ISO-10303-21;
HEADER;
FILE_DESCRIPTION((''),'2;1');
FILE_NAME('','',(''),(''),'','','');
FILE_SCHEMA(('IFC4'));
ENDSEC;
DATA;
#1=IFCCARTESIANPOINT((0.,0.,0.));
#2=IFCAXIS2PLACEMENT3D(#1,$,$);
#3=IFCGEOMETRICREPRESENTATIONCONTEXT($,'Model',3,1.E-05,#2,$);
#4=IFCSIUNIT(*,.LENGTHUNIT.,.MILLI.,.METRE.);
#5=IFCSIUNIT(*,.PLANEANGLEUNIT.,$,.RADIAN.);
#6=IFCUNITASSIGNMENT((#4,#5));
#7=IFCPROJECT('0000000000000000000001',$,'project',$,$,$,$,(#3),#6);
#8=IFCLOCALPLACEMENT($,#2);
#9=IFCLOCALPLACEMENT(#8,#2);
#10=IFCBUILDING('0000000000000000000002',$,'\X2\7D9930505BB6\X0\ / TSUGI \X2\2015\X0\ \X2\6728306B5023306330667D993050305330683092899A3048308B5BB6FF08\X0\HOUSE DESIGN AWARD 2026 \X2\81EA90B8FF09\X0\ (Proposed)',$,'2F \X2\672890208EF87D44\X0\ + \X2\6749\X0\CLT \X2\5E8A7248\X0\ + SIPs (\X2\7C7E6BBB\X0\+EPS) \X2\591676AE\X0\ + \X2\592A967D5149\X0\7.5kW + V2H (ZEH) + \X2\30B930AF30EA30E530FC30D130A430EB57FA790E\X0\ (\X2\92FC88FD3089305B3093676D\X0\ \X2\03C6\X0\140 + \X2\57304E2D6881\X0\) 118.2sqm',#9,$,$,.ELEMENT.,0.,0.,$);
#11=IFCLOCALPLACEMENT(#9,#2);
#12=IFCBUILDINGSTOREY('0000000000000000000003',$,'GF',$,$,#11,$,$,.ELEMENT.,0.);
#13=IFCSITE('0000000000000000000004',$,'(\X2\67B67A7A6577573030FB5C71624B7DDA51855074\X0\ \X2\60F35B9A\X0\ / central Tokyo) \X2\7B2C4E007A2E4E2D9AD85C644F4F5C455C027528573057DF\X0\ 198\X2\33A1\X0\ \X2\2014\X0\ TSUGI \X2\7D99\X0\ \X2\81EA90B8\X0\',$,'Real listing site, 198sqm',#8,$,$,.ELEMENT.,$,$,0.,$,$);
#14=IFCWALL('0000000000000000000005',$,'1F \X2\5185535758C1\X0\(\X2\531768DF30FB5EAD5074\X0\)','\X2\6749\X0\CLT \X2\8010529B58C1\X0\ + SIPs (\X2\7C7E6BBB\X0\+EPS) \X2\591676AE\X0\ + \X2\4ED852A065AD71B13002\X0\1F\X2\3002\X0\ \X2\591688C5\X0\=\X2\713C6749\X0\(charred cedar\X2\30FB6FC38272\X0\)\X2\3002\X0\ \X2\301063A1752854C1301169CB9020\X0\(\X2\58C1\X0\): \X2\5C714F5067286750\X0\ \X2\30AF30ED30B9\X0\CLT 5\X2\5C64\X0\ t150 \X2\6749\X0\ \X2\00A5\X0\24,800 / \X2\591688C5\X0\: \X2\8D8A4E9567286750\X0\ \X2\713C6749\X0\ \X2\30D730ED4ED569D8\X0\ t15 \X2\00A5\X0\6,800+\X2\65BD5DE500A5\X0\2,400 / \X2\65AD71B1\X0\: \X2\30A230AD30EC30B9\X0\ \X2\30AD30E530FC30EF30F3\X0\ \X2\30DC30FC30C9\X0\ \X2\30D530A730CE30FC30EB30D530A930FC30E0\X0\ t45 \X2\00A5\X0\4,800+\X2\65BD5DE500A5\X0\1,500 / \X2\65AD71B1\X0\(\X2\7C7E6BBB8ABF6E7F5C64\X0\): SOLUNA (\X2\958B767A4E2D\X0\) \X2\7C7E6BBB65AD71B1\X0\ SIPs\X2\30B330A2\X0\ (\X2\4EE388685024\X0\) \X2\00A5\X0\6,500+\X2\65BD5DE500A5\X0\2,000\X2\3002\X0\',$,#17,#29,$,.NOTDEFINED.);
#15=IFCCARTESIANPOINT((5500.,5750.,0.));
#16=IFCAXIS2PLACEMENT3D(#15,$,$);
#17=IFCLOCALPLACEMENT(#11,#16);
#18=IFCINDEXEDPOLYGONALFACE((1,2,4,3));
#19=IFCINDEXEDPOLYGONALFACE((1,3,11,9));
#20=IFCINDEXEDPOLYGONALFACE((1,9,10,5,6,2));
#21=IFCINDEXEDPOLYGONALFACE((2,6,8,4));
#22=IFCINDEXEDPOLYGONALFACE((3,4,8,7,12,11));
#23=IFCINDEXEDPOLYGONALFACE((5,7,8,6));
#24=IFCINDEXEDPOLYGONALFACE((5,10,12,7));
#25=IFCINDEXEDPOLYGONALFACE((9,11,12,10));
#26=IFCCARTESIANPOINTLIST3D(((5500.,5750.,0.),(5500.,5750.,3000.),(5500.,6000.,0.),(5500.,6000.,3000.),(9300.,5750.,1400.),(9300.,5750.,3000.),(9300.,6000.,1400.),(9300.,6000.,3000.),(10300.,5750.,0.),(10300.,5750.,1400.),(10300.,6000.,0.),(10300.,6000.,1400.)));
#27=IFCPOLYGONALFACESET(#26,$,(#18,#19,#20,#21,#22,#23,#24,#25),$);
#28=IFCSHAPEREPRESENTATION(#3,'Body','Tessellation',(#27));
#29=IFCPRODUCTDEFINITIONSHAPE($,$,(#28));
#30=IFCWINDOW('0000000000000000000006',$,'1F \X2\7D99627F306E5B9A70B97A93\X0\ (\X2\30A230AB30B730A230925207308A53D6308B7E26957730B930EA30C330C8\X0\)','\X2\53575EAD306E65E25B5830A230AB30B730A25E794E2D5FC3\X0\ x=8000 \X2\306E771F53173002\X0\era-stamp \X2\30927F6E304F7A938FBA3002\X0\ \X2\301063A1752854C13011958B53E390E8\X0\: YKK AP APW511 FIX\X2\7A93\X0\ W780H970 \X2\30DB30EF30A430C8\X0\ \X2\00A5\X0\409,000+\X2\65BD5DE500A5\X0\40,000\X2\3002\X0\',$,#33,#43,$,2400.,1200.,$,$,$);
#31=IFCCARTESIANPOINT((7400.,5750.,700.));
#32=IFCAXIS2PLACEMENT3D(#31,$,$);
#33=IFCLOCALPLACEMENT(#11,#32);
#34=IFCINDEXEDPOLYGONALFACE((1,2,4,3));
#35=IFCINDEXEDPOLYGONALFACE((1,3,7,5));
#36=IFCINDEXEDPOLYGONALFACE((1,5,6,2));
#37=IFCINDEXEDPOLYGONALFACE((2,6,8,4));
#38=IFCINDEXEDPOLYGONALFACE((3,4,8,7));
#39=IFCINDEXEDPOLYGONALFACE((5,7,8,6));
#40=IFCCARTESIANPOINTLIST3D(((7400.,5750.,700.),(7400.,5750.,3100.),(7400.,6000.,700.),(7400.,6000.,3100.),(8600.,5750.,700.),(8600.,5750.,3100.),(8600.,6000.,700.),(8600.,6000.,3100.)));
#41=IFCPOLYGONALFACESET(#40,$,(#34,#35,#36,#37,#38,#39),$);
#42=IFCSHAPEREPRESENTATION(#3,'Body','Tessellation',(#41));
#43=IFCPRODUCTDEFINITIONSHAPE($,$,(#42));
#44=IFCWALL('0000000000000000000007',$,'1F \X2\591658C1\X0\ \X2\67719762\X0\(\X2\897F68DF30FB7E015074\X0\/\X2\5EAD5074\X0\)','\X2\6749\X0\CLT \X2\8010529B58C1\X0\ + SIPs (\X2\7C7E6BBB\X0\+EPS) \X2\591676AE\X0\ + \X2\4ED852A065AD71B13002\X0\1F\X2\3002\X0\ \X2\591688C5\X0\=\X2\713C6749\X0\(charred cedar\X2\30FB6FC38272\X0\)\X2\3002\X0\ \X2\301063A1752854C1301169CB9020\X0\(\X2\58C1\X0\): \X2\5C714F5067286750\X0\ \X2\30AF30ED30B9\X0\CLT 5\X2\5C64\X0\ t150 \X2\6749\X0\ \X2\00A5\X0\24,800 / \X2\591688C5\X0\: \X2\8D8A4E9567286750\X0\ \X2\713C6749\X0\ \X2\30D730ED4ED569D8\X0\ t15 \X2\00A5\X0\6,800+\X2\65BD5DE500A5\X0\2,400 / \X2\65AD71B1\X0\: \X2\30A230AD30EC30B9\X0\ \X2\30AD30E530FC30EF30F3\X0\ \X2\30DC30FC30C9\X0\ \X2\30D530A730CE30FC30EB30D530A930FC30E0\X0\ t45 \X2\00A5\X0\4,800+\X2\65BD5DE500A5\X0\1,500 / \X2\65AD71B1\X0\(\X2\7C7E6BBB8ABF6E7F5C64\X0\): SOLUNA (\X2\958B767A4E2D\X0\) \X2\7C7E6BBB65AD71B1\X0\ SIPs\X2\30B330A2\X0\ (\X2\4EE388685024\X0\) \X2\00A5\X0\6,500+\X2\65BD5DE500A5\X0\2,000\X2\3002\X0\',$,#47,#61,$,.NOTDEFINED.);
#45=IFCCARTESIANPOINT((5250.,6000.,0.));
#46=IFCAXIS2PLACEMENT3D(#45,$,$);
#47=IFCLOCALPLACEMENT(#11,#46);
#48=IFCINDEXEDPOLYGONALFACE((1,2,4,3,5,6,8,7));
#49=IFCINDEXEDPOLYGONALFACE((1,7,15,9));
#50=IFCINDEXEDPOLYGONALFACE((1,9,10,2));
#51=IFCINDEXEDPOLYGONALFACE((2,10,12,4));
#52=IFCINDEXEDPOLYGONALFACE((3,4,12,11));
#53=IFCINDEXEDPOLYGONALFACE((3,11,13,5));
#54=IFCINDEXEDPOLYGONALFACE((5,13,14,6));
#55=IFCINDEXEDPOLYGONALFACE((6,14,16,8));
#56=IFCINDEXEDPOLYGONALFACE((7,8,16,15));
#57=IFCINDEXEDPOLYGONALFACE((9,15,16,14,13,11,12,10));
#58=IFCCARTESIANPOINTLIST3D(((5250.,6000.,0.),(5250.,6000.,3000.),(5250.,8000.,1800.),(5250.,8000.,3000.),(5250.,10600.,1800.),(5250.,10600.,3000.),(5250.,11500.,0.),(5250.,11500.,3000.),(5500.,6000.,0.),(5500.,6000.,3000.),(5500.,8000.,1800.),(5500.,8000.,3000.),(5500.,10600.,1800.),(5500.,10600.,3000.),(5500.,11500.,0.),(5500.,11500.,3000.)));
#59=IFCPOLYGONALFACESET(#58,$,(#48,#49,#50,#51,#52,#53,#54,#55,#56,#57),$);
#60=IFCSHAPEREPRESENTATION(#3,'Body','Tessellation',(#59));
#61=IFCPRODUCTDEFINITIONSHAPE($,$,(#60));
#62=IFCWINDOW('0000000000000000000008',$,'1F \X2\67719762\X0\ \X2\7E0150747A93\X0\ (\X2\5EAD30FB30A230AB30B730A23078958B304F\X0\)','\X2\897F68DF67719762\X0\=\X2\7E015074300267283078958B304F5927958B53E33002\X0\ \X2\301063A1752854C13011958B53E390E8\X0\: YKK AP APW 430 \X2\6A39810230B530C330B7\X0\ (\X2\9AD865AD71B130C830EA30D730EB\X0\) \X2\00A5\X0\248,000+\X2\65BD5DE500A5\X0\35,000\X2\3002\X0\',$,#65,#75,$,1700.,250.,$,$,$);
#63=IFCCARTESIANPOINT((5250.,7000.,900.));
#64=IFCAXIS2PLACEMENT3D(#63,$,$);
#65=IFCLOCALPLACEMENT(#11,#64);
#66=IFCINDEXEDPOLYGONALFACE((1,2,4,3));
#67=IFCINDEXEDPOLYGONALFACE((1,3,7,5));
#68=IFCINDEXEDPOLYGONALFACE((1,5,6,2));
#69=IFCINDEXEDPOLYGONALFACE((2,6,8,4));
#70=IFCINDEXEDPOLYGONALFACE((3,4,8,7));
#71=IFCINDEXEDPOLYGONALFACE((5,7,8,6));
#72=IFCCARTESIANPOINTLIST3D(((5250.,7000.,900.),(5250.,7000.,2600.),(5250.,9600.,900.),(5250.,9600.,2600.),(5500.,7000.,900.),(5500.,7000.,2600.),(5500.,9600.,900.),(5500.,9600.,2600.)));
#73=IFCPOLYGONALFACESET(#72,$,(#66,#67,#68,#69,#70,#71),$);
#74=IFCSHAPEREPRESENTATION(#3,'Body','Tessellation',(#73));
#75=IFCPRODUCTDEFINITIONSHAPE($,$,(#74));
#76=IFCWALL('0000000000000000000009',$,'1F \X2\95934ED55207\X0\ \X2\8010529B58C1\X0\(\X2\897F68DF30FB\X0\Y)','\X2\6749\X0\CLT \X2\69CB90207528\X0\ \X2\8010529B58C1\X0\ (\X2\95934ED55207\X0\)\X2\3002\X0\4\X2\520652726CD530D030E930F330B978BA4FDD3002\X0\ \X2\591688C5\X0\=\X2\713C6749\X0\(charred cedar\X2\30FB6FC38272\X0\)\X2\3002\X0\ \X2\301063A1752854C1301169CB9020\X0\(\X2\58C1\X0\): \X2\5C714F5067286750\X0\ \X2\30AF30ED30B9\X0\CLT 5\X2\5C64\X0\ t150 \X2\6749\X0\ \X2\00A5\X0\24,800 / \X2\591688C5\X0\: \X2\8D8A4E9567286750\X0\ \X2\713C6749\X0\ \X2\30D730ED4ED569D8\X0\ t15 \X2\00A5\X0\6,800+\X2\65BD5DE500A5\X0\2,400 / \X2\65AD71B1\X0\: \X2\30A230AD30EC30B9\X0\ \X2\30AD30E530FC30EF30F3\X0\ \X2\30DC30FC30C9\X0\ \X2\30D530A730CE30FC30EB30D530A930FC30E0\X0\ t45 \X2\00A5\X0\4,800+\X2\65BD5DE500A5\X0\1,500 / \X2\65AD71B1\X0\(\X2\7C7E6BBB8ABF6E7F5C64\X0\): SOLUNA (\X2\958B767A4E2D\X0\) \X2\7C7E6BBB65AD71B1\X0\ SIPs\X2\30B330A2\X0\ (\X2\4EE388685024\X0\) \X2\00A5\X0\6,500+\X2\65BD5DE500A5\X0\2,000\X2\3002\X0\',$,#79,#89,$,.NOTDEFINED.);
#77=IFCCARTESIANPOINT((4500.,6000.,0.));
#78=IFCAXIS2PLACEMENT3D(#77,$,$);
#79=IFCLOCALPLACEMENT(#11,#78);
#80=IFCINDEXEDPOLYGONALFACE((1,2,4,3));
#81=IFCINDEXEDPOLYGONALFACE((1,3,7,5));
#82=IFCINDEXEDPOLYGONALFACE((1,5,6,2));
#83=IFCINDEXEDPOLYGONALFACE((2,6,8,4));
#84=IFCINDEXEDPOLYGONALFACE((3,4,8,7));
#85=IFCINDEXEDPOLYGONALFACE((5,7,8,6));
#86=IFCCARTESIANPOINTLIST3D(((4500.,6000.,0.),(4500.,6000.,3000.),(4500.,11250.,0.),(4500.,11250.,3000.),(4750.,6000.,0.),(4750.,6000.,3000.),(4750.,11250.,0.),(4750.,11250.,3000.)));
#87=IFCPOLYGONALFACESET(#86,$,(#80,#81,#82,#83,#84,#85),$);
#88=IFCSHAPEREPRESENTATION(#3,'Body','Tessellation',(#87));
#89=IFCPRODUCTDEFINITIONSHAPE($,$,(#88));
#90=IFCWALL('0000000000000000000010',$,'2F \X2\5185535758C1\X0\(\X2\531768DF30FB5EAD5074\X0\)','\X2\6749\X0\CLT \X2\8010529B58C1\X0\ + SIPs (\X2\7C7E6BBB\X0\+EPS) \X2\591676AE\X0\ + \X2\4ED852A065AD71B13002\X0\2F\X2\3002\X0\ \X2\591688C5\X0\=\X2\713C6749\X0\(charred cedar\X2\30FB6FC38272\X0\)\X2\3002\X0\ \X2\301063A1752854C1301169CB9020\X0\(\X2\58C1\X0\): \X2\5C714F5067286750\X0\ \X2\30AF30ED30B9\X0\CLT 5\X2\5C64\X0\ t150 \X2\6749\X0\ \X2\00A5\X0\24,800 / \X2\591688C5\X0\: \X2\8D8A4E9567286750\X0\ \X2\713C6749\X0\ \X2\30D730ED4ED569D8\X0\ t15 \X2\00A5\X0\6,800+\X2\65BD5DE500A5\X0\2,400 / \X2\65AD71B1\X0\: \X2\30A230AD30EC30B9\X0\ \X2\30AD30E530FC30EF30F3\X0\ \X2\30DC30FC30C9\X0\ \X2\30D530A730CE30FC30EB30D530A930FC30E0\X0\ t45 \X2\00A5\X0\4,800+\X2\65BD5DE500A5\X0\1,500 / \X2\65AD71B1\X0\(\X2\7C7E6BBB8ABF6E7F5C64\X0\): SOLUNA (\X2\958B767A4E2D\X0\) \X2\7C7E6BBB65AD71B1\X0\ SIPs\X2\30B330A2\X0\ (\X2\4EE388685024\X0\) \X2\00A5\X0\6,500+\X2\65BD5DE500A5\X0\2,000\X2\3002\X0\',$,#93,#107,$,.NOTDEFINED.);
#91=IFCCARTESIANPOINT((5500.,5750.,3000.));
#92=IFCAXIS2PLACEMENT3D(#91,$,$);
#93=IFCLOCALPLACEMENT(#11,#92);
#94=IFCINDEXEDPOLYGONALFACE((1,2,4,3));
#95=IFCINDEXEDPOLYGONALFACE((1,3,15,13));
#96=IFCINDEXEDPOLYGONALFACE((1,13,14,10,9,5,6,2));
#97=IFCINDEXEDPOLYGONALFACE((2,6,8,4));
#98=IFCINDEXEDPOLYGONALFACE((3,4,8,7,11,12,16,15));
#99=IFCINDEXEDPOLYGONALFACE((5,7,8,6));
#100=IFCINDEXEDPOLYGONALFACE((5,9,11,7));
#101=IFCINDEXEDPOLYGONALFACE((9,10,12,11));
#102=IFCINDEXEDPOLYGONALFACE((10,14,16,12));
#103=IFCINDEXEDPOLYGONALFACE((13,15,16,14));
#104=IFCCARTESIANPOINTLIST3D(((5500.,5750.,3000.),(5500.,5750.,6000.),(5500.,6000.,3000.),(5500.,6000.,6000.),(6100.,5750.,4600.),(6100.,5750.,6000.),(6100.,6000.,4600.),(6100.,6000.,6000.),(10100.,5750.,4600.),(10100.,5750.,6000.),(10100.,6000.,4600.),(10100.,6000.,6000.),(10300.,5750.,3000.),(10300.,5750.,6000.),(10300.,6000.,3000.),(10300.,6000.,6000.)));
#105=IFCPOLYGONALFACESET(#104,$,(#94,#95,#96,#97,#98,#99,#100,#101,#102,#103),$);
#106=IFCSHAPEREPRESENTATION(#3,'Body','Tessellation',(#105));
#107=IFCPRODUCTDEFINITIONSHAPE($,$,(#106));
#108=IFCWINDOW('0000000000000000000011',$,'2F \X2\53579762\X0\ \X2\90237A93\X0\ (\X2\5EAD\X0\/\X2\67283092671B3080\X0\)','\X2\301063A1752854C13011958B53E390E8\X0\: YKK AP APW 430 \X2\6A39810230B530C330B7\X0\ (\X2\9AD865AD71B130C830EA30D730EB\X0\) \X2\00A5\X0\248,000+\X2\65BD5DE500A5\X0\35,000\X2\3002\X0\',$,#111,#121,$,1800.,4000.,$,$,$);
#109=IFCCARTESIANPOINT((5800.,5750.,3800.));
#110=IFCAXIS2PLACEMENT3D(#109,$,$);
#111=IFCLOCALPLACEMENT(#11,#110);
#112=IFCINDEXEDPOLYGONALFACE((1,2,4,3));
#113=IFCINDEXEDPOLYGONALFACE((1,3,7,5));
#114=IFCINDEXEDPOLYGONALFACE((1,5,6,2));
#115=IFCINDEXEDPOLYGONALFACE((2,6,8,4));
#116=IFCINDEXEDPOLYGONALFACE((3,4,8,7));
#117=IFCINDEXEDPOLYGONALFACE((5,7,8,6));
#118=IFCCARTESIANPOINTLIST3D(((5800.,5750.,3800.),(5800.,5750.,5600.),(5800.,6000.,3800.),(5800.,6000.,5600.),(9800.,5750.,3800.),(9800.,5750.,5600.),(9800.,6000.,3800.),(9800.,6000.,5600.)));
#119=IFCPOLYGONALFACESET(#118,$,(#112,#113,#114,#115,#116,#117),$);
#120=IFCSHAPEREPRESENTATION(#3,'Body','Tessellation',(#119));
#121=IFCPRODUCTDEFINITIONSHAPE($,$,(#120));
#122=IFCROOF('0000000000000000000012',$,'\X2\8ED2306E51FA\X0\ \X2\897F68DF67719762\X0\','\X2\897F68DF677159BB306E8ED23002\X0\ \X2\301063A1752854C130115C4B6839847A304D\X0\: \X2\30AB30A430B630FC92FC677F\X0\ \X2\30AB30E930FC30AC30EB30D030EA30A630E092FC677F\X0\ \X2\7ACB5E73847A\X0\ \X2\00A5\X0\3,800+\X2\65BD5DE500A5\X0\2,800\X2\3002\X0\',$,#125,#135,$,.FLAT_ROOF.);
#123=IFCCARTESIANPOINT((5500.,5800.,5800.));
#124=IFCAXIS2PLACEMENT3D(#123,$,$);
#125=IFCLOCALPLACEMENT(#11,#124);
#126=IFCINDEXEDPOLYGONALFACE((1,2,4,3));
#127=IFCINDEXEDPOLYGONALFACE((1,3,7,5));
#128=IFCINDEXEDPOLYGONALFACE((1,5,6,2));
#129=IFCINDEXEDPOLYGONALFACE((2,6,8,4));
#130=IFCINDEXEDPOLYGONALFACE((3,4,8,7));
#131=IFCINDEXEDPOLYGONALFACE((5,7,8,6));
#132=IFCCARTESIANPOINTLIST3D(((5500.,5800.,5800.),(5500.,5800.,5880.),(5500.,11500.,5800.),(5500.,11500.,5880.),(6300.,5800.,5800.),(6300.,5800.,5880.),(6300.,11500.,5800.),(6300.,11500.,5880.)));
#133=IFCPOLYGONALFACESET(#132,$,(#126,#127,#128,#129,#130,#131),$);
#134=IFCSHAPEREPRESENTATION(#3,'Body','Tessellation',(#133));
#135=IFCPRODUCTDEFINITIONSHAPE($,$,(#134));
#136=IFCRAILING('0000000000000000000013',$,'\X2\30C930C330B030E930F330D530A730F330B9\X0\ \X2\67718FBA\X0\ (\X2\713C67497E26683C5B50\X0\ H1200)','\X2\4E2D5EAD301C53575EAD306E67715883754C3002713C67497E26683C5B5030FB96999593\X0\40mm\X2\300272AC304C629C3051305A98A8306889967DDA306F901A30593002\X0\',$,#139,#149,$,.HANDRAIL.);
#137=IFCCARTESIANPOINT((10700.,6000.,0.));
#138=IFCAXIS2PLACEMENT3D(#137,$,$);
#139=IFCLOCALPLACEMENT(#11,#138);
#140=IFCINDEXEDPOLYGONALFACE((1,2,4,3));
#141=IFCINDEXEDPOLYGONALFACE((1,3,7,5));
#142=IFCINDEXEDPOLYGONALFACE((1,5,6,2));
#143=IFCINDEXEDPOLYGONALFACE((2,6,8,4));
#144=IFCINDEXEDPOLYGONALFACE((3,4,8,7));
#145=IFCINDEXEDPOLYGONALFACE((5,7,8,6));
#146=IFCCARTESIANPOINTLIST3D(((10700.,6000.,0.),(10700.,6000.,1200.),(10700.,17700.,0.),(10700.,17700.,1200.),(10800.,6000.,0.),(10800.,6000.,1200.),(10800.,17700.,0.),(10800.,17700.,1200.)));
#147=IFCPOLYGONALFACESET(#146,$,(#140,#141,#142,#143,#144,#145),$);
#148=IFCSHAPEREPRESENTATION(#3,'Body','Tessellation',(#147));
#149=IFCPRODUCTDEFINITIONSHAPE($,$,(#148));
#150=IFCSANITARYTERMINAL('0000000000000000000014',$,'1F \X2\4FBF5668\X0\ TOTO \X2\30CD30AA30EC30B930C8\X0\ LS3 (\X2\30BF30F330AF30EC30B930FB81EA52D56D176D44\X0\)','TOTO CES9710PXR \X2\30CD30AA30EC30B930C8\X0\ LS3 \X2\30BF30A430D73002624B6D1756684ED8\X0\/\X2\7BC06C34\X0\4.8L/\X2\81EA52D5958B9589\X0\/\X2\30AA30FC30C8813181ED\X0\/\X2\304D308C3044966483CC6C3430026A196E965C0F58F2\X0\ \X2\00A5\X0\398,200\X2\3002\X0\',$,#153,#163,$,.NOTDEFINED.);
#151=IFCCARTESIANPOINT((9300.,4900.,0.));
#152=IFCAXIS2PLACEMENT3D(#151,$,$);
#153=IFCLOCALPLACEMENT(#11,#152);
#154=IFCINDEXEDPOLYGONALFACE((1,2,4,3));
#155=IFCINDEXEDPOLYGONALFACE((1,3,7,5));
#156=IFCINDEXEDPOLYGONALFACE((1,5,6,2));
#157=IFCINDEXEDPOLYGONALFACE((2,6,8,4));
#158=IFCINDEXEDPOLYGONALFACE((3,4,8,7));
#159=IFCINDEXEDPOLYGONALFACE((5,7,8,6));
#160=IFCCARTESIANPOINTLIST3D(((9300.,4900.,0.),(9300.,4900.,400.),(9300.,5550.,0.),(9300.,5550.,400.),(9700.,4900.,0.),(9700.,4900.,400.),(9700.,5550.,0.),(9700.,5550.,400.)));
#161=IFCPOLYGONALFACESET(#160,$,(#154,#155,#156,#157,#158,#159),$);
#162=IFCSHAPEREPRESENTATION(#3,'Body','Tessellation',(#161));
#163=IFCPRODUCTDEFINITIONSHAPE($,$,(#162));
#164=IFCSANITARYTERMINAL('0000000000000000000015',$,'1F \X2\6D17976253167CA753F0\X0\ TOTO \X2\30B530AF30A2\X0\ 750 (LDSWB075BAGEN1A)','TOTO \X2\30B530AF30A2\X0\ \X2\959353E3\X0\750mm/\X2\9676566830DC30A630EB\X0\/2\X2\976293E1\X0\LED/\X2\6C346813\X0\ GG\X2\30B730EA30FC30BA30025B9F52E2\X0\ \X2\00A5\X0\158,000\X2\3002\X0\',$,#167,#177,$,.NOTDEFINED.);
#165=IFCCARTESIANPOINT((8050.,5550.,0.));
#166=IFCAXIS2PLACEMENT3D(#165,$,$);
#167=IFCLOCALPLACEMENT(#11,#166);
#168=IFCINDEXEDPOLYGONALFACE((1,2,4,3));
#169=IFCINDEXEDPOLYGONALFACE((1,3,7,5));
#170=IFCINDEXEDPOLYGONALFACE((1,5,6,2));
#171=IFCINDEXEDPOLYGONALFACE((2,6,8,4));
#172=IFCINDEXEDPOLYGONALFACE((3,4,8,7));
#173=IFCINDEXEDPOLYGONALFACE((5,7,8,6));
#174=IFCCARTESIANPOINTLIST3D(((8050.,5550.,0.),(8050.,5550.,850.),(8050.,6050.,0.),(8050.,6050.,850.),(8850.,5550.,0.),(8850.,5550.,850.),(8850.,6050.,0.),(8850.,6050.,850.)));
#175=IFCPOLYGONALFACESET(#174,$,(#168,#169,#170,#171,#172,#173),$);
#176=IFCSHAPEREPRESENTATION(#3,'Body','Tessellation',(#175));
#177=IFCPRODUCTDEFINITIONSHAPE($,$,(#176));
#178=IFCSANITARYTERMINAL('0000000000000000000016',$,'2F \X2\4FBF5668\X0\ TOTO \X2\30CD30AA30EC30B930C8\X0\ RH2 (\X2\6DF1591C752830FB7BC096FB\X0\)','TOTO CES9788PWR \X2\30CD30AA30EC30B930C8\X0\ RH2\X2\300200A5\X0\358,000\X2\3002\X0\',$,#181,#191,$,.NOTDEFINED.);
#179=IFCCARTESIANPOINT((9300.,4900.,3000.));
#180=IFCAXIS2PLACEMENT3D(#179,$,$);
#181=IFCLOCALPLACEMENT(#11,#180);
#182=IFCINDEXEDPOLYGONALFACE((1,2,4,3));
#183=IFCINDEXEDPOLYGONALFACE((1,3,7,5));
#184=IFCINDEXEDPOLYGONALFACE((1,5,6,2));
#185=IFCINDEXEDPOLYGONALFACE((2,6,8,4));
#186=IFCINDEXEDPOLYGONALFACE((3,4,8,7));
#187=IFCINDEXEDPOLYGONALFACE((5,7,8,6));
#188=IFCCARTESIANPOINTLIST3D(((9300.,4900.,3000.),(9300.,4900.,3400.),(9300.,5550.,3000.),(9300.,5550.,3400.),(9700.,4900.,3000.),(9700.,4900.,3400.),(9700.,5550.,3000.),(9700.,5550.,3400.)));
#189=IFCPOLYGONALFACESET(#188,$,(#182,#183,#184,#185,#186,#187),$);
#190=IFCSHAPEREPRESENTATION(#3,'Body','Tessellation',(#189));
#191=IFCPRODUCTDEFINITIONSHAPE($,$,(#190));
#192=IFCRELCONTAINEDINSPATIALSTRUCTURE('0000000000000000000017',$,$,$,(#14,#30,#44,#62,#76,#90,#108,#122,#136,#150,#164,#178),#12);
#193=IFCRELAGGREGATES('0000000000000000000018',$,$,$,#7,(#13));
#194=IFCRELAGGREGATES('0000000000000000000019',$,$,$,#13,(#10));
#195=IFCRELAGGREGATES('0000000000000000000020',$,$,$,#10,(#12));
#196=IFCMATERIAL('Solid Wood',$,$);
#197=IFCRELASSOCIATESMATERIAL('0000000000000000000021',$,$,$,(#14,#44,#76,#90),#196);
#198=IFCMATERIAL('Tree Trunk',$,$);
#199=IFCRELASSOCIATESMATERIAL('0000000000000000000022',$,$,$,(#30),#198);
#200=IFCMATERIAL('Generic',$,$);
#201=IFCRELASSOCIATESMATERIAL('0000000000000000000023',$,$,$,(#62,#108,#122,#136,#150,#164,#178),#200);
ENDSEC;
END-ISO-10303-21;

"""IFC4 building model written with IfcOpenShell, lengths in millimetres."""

from ifc_helpers import new_model, si_unit, frame, frame_2d, origin, place, context, project, spatial, rectangle, extrude, material, element, fill, save


model = new_model("IFC4")

# Units and contexts
model_context = context("Model", 3, precision=1e-05, world=origin())
ifc_project = project(units=[si_unit("LENGTHUNIT", "METRE", prefix="MILLI"), si_unit("PLANEANGLEUNIT", "RADIAN")], contexts=[model_context])

# Site, building, storey
site_placement = place(None, origin())
site = spatial("IfcSite", under=ifc_project, at=site_placement, Name="(架空敷地・山手線内側 想定 / central Tokyo) 第一種中高層住居専用地域 198㎡ — TSUGI 継 自邸", ObjectType="Real listing site, 198sqm", CompositionType="ELEMENT", RefElevation=0.0)
building_placement = place(site_placement, origin())
building = spatial("IfcBuilding", under=site, at=building_placement, Name="継ぐ家 / TSUGI ― 木に倣って継ぐことを覚える家（HOUSE DESIGN AWARD 2026 自邸） (Proposed)", ObjectType="2F 木造軸組 + 杉CLT 床版 + SIPs (籾殻+EPS) 外皮 + 太陽光7.5kW + V2H (ZEH) + スクリューパイル基礎 (鋼製らせん杭 φ140 + 地中梁) 118.2sqm", CompositionType="ELEMENT", ElevationOfRefHeight=0.0, ElevationOfTerrain=0.0)
storey_placement = place(building_placement, origin())
storey = spatial("IfcBuildingStorey", under=building, at=storey_placement, Name="GF", CompositionType="ELEMENT", Elevation=0.0)

# Shared definitions
ifc_material_1 = material(Name="Generic")

# Walls, openings, windows
ifc_material_2 = material(Name="Solid Wood")
wall_1_placement = place(storey_placement, frame((5500.0, 5750.0, 0.0)))
wall_1 = element("IfcWall", 1, at=wall_1_placement, inside=storey, material=ifc_material_2, Name="1F 内南壁(北棟・庭側)", Description="杉CLT 耐力壁 + SIPs (籾殻+EPS) 外皮 + 付加断熱。1F。 外装=焼杉(charred cedar・濃色)。 【採用品】構造(壁): 山佐木材 クロスCLT 5層 t150 杉 ¥24,800 / 外装: 越井木材 焼杉 プロ仕様 t15 ¥6,800+施工¥2,400 / 断熱: アキレス キューワン ボード フェノールフォーム t45 ¥4,800+施工¥1,500 / 断熱(籾殻調湿層): SOLUNA (開発中) 籾殻断熱 SIPsコア (代表値) ¥6,500+施工¥2,000。", PredefinedType="NOTDEFINED", context=model_context, shape_type="SweptSolid", body=[
    extrude(rectangle(XDim=4800.0, YDim=250.0, at=frame_2d((2400.0, 125.0))), frame((5500.0, 5750.0, 0.0)), (0.0, 0.0, 1.0), 3000.0),
])
opening_1_placement = place(storey_placement, frame((7400.0, 5750.0, 700.0)))
opening_1 = element("IfcOpeningElement", 2, at=opening_1_placement, cuts=wall_1, PredefinedType="NOTDEFINED", context=model_context, shape_type="SweptSolid", body=[
    extrude(rectangle(XDim=1200.0, YDim=250.0, at=frame_2d((600.0, 125.0))), frame((7400.0, 5750.0, 700.0)), (0.0, 0.0, 1.0), 2400.0),
])
ifc_material_3 = material(Name="Tree Trunk")
window_1_placement = place(storey_placement, frame((7400.0, 5750.0, 700.0)))
window_1 = element("IfcWindow", 3, at=window_1_placement, inside=storey, material=ifc_material_3, Name="1F 継承の定点窓 (アカシアを切り取る縦長スリット)", Description="南庭の既存アカシア幹中心 x=8000 の真北。era-stamp を置く窓辺。 【採用品】開口部: YKK AP APW511 FIX窓 W780H970 ホワイト ¥409,000+施工¥40,000。", OverallHeight=2400.0, OverallWidth=1200.0, context=model_context, shape_type="SweptSolid", body=[
    extrude(rectangle(XDim=1200.0, YDim=250.0, at=frame_2d((600.0, 125.0))), frame((7400.0, 5750.0, 700.0)), (0.0, 0.0, 1.0), 2400.0),
])
fill(opening_1, window_1)
wall_2_placement = place(storey_placement, frame((5250.0, 6000.0, 0.0)))
wall_2 = element("IfcWall", 4, at=wall_2_placement, inside=storey, material=ifc_material_2, Name="1F 外壁 東面(西棟・縁側/庭側)", Description="杉CLT 耐力壁 + SIPs (籾殻+EPS) 外皮 + 付加断熱。1F。 外装=焼杉(charred cedar・濃色)。 【採用品】構造(壁): 山佐木材 クロスCLT 5層 t150 杉 ¥24,800 / 外装: 越井木材 焼杉 プロ仕様 t15 ¥6,800+施工¥2,400 / 断熱: アキレス キューワン ボード フェノールフォーム t45 ¥4,800+施工¥1,500 / 断熱(籾殻調湿層): SOLUNA (開発中) 籾殻断熱 SIPsコア (代表値) ¥6,500+施工¥2,000。", PredefinedType="NOTDEFINED", context=model_context, shape_type="SweptSolid", body=[
    extrude(rectangle(XDim=250.0, YDim=5500.0, at=frame_2d((125.0, 2750.0))), frame((5250.0, 6000.0, 0.0)), (0.0, 0.0, 1.0), 3000.0),
])
opening_2_placement = place(storey_placement, frame((5250.0, 7000.0, 900.0)))
opening_2 = element("IfcOpeningElement", 5, at=opening_2_placement, cuts=wall_2, PredefinedType="NOTDEFINED", context=model_context, shape_type="SweptSolid", body=[
    extrude(rectangle(XDim=250.0, YDim=2600.0, at=frame_2d((125.0, 1300.0))), frame((5250.0, 7000.0, 900.0)), (0.0, 0.0, 1.0), 1700.0),
])
window_2_placement = place(storey_placement, frame((5250.0, 7000.0, 900.0)))
window_2 = element("IfcWindow", 6, at=window_2_placement, inside=storey, material=ifc_material_1, Name="1F 東面 縁側窓 (庭・アカシアへ開く)", Description="西棟東面=縁側。木へ開く大開口。 【採用品】開口部: YKK AP APW 430 樹脂サッシ (高断熱トリプル) ¥248,000+施工¥35,000。", OverallHeight=1700.0, OverallWidth=250.0, context=model_context, shape_type="SweptSolid", body=[
    extrude(rectangle(XDim=250.0, YDim=2600.0, at=frame_2d((125.0, 1300.0))), frame((5250.0, 7000.0, 900.0)), (0.0, 0.0, 1.0), 1700.0),
])
fill(opening_2, window_2)

# Wall
wall_3_placement = place(storey_placement, frame((4500.0, 6000.0, 0.0)))
element("IfcWall", 7, at=wall_3_placement, inside=storey, material=ifc_material_2, Name="1F 間仕切 耐力壁(西棟・Y)", Description="杉CLT 構造用 耐力壁 (間仕切)。4分割法バランス確保。 外装=焼杉(charred cedar・濃色)。 【採用品】構造(壁): 山佐木材 クロスCLT 5層 t150 杉 ¥24,800 / 外装: 越井木材 焼杉 プロ仕様 t15 ¥6,800+施工¥2,400 / 断熱: アキレス キューワン ボード フェノールフォーム t45 ¥4,800+施工¥1,500 / 断熱(籾殻調湿層): SOLUNA (開発中) 籾殻断熱 SIPsコア (代表値) ¥6,500+施工¥2,000。", PredefinedType="NOTDEFINED", context=model_context, shape_type="SweptSolid", body=[
    extrude(rectangle(XDim=250.0, YDim=5250.0, at=frame_2d((125.0, 2625.0))), frame((4500.0, 6000.0, 0.0)), (0.0, 0.0, 1.0), 3000.0),
])

# Wall, opening, window
wall_4_placement = place(storey_placement, frame((5500.0, 5750.0, 3000.0)))
wall_4 = element("IfcWall", 8, at=wall_4_placement, inside=storey, material=ifc_material_2, Name="2F 内南壁(北棟・庭側)", Description="杉CLT 耐力壁 + SIPs (籾殻+EPS) 外皮 + 付加断熱。2F。 外装=焼杉(charred cedar・濃色)。 【採用品】構造(壁): 山佐木材 クロスCLT 5層 t150 杉 ¥24,800 / 外装: 越井木材 焼杉 プロ仕様 t15 ¥6,800+施工¥2,400 / 断熱: アキレス キューワン ボード フェノールフォーム t45 ¥4,800+施工¥1,500 / 断熱(籾殻調湿層): SOLUNA (開発中) 籾殻断熱 SIPsコア (代表値) ¥6,500+施工¥2,000。", PredefinedType="NOTDEFINED", context=model_context, shape_type="SweptSolid", body=[
    extrude(rectangle(XDim=4800.0, YDim=250.0, at=frame_2d((2400.0, 125.0))), frame((5500.0, 5750.0, 3000.0)), (0.0, 0.0, 1.0), 3000.0),
])
opening_3_placement = place(storey_placement, frame((5800.0, 5750.0, 3800.0)))
opening_3 = element("IfcOpeningElement", 9, at=opening_3_placement, cuts=wall_4, PredefinedType="NOTDEFINED", context=model_context, shape_type="SweptSolid", body=[
    extrude(rectangle(XDim=4000.0, YDim=250.0, at=frame_2d((2000.0, 125.0))), frame((5800.0, 5750.0, 3800.0)), (0.0, 0.0, 1.0), 1800.0),
])
window_3_placement = place(storey_placement, frame((5800.0, 5750.0, 3800.0)))
window_3 = element("IfcWindow", 10, at=window_3_placement, inside=storey, material=ifc_material_1, Name="2F 南面 連窓 (庭/木を望む)", Description="【採用品】開口部: YKK AP APW 430 樹脂サッシ (高断熱トリプル) ¥248,000+施工¥35,000。", OverallHeight=1800.0, OverallWidth=4000.0, context=model_context, shape_type="SweptSolid", body=[
    extrude(rectangle(XDim=4000.0, YDim=250.0, at=frame_2d((2000.0, 125.0))), frame((5800.0, 5750.0, 3800.0)), (0.0, 0.0, 1.0), 1800.0),
])
fill(opening_3, window_3)

# Roof
roof_placement = place(storey_placement, frame((5500.0, 5800.0, 5800.0)))
element("IfcRoof", 11, at=roof_placement, inside=storey, material=ifc_material_1, Name="軒の出 西棟東面", Description="西棟東妻の軒。 【採用品】屋根葺き: カイザー鋼板 カラーガルバリウム鋼板 立平葺 ¥3,800+施工¥2,800。", PredefinedType="FLAT_ROOF", context=model_context, shape_type="SweptSolid", body=[
    extrude(rectangle(XDim=800.0, YDim=5700.0, at=frame_2d((400.0, 2850.0))), frame((5500.0, 5800.0, 5800.0)), (0.0, 0.0, 1.0), 80.0),
])

# Railing
railing_placement = place(storey_placement, frame((10700.0, 6000.0, 0.0)))
element("IfcRailing", 12, at=railing_placement, inside=storey, material=ifc_material_1, Name="ドッグランフェンス 東辺 (焼杉縦格子 H1200)", Description="中庭〜南庭の東境界。焼杉縦格子・隙間40mm。犬が抜けず風と視線は通す。", PredefinedType="HANDRAIL", context=model_context, shape_type="SweptSolid", body=[
    extrude(rectangle(XDim=100.0, YDim=11700.0, at=frame_2d((50.0, 5850.0))), frame((10700.0, 6000.0, 0.0)), (0.0, 0.0, 1.0), 1200.0),
])

# Sanitary terminals
sanitary_terminal_1_placement = place(storey_placement, frame((9300.0, 4900.0, 0.0)))
element("IfcSanitaryTerminal", 13, at=sanitary_terminal_1_placement, inside=storey, material=ifc_material_1, Name="1F 便器 TOTO ネオレスト LS3 (タンクレス・自動洗浄)", Description="TOTO CES9710PXR ネオレスト LS3 タイプ。手洗器付/節水4.8L/自動開閉/オート脱臭/きれい除菌水。標準小売 ¥398,200。", PredefinedType="NOTDEFINED", context=model_context, shape_type="SweptSolid", body=[
    extrude(rectangle(XDim=400.0, YDim=650.0, at=frame_2d((200.0, 325.0))), frame((9300.0, 4900.0, 0.0)), (0.0, 0.0, 1.0), 400.0),
])
sanitary_terminal_2_placement = place(storey_placement, frame((8050.0, 5550.0, 0.0)))
element("IfcSanitaryTerminal", 14, at=sanitary_terminal_2_placement, inside=storey, material=ifc_material_1, Name="1F 洗面化粧台 TOTO サクア 750 (LDSWB075BAGEN1A)", Description="TOTO サクア 間口750mm/陶器ボウル/2面鏡LED/水栓 GGシリーズ。実勢 ¥158,000。", PredefinedType="NOTDEFINED", context=model_context, shape_type="SweptSolid", body=[
    extrude(rectangle(XDim=800.0, YDim=500.0, at=frame_2d((400.0, 250.0))), frame((8050.0, 5550.0, 0.0)), (0.0, 0.0, 1.0), 850.0),
])
sanitary_terminal_3_placement = place(storey_placement, frame((9300.0, 4900.0, 3000.0)))
element("IfcSanitaryTerminal", 15, at=sanitary_terminal_3_placement, inside=storey, material=ifc_material_1, Name="2F 便器 TOTO ネオレスト RH2 (深夜用・節電)", Description="TOTO CES9788PWR ネオレスト RH2。¥358,000。", PredefinedType="NOTDEFINED", context=model_context, shape_type="SweptSolid", body=[
    extrude(rectangle(XDim=400.0, YDim=650.0, at=frame_2d((200.0, 325.0))), frame((9300.0, 4900.0, 3000.0)), (0.0, 0.0, 1.0), 400.0),
])

save(model, "model.ifc")
